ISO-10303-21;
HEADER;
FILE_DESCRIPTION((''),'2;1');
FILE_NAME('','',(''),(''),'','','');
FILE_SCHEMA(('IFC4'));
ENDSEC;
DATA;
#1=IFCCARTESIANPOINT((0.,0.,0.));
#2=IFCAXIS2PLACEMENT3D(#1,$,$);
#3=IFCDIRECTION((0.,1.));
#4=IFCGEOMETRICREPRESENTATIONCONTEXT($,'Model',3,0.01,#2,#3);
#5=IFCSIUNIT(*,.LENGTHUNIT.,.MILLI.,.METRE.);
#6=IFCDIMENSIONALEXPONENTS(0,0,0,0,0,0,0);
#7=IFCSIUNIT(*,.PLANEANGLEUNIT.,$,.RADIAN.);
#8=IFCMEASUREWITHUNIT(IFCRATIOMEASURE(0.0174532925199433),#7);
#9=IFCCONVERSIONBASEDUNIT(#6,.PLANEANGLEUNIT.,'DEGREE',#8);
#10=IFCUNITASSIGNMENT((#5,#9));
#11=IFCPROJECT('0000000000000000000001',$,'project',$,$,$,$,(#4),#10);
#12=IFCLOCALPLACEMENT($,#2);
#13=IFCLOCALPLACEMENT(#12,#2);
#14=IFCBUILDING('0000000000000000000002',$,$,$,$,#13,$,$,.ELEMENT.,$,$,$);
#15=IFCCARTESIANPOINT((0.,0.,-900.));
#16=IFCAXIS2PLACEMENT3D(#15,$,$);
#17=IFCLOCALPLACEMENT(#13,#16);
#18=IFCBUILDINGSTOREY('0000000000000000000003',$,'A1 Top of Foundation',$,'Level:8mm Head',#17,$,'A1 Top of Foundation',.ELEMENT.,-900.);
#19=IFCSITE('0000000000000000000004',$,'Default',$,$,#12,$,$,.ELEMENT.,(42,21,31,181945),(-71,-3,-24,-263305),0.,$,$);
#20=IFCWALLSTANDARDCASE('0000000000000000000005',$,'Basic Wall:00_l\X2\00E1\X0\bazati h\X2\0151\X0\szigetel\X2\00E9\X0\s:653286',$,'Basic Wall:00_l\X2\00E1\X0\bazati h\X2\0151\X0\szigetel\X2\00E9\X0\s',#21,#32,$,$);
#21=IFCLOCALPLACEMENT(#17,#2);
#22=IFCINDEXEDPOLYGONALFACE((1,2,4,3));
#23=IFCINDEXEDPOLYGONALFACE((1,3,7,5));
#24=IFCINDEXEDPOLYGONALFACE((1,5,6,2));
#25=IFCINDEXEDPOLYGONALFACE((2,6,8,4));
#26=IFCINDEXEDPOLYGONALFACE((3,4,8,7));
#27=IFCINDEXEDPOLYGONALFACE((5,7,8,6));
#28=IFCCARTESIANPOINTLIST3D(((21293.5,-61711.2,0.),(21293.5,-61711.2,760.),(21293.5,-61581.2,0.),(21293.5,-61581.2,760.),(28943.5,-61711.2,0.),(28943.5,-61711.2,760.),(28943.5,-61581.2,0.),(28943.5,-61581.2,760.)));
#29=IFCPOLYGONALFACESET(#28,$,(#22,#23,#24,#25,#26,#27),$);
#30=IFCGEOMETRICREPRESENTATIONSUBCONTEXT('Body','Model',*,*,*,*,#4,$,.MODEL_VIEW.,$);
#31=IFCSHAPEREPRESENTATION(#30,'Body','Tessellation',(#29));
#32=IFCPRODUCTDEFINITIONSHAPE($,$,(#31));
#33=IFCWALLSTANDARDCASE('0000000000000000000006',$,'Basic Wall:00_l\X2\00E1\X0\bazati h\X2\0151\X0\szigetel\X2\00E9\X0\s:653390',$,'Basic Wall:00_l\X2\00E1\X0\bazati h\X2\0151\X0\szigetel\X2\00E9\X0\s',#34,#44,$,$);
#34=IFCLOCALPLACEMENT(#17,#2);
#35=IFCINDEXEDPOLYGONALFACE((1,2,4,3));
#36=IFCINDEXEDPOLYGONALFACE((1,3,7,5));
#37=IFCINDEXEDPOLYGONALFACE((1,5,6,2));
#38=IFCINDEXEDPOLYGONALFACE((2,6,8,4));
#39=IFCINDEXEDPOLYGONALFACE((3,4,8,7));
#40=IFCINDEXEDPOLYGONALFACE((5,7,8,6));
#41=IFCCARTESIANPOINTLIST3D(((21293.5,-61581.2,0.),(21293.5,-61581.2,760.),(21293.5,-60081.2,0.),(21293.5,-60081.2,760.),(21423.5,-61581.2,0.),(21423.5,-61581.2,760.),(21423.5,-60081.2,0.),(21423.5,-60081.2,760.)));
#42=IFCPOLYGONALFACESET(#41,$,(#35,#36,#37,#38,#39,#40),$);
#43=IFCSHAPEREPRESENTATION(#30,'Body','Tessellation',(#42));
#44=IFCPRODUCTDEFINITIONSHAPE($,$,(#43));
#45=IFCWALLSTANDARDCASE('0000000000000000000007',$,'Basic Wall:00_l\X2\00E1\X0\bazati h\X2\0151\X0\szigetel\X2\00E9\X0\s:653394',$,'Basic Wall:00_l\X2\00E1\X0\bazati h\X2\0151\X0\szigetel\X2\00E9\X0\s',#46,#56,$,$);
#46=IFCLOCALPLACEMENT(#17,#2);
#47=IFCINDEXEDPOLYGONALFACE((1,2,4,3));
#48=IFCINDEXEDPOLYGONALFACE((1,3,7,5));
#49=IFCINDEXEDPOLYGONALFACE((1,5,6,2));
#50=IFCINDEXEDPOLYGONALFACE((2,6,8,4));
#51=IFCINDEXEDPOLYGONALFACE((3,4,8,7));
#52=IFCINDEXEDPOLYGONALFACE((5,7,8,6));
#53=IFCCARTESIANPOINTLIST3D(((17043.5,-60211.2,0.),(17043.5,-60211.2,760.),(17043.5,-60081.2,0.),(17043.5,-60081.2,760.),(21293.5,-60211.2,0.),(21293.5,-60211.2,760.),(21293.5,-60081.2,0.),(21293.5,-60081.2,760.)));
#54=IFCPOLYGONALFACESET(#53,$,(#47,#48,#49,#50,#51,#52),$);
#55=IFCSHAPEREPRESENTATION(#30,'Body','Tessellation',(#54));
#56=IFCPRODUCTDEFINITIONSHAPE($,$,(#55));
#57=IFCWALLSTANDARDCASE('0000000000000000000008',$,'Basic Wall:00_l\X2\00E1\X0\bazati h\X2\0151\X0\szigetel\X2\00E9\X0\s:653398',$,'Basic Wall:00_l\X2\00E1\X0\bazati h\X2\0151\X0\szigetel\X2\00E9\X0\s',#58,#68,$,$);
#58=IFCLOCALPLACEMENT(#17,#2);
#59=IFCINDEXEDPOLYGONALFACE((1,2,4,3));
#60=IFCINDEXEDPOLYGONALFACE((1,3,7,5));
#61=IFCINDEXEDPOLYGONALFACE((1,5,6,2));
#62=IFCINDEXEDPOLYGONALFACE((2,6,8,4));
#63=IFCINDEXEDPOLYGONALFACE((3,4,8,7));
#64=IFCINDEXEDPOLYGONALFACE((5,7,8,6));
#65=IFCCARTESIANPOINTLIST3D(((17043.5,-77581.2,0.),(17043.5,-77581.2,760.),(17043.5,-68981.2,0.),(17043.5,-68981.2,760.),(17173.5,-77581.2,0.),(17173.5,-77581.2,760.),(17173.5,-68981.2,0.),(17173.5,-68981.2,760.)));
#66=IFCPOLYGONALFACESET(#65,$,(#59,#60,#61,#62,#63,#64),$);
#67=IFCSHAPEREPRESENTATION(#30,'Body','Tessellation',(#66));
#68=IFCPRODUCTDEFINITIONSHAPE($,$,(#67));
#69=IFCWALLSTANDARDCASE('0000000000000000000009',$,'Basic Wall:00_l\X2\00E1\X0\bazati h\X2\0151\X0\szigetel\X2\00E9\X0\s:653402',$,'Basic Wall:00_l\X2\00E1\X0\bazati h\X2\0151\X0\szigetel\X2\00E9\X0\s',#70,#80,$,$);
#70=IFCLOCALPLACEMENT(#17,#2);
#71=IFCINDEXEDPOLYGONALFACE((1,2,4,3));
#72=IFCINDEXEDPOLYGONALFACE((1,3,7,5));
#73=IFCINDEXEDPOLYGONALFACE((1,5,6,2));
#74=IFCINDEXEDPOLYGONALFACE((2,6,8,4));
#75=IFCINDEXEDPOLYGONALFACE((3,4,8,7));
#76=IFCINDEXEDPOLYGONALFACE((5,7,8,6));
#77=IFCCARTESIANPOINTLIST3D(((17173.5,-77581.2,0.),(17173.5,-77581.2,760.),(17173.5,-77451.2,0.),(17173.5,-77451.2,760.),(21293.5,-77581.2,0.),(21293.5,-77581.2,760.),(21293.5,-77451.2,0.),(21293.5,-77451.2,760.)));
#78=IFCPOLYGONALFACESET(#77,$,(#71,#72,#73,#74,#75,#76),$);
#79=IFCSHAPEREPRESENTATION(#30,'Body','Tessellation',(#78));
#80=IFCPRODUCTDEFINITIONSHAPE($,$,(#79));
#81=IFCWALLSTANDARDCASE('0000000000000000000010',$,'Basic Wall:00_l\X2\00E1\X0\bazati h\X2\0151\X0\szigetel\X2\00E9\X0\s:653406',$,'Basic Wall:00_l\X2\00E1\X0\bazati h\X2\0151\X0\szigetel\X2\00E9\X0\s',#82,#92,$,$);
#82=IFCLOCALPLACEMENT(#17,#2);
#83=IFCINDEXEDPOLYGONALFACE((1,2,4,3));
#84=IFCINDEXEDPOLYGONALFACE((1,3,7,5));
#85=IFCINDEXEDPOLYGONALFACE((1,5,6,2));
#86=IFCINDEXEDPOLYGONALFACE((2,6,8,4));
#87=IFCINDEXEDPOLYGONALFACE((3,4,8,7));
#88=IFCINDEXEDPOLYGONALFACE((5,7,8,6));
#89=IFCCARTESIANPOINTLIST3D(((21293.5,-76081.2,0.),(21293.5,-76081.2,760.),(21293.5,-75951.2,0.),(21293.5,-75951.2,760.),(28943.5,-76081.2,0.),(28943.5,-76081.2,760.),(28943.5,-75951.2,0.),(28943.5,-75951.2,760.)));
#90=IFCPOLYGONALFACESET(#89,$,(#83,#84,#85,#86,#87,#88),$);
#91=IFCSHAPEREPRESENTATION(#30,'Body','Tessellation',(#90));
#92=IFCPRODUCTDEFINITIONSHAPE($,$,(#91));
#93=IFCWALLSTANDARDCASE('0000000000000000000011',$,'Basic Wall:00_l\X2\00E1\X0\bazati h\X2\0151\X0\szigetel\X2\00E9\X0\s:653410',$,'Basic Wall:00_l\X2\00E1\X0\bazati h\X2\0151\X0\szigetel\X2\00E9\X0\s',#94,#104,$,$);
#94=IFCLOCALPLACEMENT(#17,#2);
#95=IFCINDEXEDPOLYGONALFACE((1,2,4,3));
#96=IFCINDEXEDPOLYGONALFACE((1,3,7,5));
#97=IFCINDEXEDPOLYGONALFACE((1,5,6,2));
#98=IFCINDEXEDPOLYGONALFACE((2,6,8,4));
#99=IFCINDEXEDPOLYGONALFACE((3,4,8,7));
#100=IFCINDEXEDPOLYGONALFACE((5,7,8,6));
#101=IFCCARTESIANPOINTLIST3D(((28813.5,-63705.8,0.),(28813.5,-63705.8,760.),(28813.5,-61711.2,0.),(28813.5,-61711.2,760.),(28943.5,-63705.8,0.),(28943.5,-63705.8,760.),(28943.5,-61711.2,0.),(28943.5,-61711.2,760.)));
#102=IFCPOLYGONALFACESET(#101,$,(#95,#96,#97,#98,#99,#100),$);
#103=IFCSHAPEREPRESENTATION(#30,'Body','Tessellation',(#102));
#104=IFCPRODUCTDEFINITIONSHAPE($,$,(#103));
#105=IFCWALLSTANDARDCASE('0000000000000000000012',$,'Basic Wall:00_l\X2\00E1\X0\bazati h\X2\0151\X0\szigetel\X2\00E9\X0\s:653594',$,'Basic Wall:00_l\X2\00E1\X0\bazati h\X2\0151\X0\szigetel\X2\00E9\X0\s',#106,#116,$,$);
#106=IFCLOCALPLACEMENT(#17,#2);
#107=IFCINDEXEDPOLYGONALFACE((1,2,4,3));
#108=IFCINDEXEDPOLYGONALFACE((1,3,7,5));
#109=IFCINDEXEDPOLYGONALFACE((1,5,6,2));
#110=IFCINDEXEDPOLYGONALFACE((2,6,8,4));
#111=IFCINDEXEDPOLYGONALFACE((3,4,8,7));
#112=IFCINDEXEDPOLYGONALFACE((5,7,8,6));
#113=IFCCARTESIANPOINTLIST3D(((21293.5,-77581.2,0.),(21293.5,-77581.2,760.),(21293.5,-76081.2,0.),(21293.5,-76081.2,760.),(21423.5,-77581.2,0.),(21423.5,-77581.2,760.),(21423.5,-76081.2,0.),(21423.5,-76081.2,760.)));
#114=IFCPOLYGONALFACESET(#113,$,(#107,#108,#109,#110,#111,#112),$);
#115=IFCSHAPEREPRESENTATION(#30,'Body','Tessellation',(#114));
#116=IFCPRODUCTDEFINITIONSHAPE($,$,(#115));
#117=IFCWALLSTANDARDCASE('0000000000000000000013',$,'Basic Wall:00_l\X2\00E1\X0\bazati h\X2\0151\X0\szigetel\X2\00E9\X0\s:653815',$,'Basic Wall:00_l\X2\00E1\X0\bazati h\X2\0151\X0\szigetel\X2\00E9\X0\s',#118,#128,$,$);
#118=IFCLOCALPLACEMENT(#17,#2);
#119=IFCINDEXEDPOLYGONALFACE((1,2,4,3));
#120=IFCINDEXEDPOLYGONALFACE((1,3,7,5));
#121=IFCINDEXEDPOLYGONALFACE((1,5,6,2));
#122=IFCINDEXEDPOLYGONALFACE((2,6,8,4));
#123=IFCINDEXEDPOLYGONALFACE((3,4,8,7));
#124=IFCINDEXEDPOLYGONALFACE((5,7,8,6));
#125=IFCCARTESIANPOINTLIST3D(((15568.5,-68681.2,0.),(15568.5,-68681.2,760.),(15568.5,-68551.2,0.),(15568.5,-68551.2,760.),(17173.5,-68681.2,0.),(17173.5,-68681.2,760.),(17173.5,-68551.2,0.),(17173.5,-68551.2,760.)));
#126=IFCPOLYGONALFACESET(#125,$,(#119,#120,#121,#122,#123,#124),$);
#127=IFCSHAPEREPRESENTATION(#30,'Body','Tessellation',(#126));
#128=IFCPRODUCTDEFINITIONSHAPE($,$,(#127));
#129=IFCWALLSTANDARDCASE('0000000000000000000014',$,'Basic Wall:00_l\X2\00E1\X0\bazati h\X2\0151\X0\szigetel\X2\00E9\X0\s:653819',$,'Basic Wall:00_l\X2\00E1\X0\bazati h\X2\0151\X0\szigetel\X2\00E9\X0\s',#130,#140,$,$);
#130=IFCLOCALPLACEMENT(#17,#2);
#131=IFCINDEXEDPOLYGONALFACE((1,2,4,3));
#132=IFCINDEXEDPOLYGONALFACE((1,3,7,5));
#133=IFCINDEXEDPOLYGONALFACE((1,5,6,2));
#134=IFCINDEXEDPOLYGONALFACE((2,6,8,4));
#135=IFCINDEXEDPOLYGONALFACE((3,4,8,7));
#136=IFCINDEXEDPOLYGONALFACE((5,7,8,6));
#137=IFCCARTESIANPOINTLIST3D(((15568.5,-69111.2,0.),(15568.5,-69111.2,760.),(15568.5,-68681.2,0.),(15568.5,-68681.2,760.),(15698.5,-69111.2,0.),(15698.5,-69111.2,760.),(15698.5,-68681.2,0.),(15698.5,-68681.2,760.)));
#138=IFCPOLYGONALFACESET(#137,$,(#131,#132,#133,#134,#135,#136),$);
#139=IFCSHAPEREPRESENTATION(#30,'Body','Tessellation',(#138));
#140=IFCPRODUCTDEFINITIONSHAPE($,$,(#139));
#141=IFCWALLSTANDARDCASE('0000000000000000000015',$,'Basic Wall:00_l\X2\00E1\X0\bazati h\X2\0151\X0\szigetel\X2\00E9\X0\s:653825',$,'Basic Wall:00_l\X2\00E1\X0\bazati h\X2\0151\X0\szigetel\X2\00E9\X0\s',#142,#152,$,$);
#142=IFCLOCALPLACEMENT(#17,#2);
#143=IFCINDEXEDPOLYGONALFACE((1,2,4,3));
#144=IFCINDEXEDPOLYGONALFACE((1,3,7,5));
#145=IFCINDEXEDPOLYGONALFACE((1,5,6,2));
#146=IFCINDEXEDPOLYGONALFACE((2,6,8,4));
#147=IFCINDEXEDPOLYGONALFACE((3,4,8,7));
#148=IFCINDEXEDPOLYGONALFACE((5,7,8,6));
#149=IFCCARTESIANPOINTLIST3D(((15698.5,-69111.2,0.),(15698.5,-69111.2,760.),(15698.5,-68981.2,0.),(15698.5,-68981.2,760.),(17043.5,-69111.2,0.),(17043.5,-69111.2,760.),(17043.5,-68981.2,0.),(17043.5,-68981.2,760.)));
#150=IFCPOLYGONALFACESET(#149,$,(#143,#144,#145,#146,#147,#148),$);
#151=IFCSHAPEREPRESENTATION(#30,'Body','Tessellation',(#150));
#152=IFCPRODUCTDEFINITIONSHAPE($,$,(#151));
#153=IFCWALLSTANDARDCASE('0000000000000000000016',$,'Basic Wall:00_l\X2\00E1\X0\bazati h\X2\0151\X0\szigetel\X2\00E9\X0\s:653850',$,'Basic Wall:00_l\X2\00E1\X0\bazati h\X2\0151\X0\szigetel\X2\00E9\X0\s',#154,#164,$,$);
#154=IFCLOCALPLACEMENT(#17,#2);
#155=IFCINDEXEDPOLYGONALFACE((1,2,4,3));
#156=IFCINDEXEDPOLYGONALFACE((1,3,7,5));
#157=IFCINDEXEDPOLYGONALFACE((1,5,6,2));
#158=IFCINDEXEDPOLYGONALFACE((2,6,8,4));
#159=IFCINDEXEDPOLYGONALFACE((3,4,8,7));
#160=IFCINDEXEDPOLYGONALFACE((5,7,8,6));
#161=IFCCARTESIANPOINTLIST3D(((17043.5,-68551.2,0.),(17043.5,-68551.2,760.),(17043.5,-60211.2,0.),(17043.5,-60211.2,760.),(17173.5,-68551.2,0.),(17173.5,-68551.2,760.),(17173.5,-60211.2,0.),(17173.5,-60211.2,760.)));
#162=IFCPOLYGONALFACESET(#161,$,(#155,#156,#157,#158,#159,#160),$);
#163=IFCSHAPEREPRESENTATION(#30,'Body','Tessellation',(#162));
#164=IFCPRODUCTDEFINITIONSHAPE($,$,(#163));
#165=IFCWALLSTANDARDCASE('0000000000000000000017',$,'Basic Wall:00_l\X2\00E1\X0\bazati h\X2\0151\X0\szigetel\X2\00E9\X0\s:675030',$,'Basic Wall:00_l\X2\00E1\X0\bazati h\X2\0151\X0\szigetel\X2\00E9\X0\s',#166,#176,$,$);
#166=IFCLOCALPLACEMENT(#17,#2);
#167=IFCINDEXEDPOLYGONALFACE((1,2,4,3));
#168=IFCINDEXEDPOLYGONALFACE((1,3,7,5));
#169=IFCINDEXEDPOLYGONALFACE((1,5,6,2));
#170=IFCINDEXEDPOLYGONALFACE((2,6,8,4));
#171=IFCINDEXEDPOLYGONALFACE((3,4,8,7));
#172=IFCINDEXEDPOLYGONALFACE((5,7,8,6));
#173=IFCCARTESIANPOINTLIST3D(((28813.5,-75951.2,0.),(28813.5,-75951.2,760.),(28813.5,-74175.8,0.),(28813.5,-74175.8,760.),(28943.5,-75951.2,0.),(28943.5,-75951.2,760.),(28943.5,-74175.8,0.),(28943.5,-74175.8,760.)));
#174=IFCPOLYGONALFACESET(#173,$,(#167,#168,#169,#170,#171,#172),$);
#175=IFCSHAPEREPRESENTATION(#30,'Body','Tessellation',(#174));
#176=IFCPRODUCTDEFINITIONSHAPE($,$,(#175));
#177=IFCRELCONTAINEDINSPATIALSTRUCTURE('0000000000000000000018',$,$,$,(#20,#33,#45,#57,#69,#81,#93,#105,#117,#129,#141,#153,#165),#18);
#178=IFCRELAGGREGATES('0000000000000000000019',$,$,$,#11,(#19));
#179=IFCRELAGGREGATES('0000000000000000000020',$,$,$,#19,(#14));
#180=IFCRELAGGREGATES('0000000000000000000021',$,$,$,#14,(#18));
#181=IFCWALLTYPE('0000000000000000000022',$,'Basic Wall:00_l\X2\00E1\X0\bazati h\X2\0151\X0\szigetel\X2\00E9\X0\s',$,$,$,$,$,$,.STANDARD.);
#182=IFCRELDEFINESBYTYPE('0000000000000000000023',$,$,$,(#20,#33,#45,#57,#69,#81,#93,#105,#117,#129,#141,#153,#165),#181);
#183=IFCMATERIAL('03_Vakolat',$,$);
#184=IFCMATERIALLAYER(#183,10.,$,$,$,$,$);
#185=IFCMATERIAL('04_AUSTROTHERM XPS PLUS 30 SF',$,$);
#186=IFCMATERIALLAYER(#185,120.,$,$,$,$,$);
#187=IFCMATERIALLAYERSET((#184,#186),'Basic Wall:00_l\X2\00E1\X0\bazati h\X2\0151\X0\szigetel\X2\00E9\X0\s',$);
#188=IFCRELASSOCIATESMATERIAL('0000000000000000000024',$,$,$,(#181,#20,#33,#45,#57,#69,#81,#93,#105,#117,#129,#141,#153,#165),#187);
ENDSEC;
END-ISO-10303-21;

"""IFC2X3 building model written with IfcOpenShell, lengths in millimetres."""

from ifc_helpers import new_model, entity, si_unit, converted_unit, direction, frame, frame_2d, origin, place, context, subcontext, project, spatial, rectangle, extrude, material, layer, layer_set, layer_usage, type_object, element, save


model = new_model("IFC2X3")

# Units and contexts
model_context = context("Model", 3, precision=0.01, world=origin(), true_north=direction((0.0, 1.0)))
body_context = subcontext(model_context, "Body", "Model", "MODEL_VIEW")
ifc_project = project(units=[si_unit("LENGTHUNIT", "METRE", prefix="MILLI"), converted_unit("PLANEANGLEUNIT", "DEGREE", entity("IfcRatioMeasure", 0.0174532925199433), si_unit("PLANEANGLEUNIT", "RADIAN"), dimensions=[0, 0, 0, 0, 0, 0, 0])], contexts=[model_context])

# Site, building, storey
site_placement = place(None, origin())
site = spatial("IfcSite", under=ifc_project, at=site_placement, Name="Default", CompositionType="ELEMENT", RefLatitude=(42, 21, 31, 181945), RefLongitude=(-71, -3, -24, -263305), RefElevation=0.0)
building_placement = place(site_placement, origin())
building = spatial("IfcBuilding", under=site, at=building_placement, CompositionType="ELEMENT")
storey_placement = place(building_placement, frame((0.0, 0.0, -900.0)))
storey = spatial("IfcBuildingStorey", under=building, at=storey_placement, Name="A1 Top of Foundation", ObjectType="Level:8mm Head", LongName="A1 Top of Foundation", CompositionType="ELEMENT", Elevation=-900.0)

# Walls
ifc_material_1 = material(Name="03_Vakolat")
ifc_layer_1 = layer(ifc_material_1, 10.0)
ifc_material_2 = material(Name="04_AUSTROTHERM XPS PLUS 30 SF")
ifc_layer_2 = layer(ifc_material_2, 120.0)
ifc_layer_set = layer_set([ifc_layer_1, ifc_layer_2], Name="Basic Wall:00_lábazati hőszigetelés")
ifc_layer_usage_1 = layer_usage(ifc_layer_set, "AXIS2", "NEGATIVE", 65.0)
wall_type = type_object("IfcWallType", Name="Basic Wall:00_lábazati hőszigetelés", PredefinedType="STANDARD", material=ifc_layer_set)
wall_1_placement = place(storey_placement, frame((21293.5, -61646.2, 0.0)))
element("IfcWallStandardCase", 1, at=wall_1_placement, inside=storey, type_object=wall_type, material=ifc_layer_usage_1, Name="Basic Wall:00_lábazati hőszigetelés:653286", ObjectType="Basic Wall:00_lábazati hőszigetelés", context=body_context, shape_type="SweptSolid", body=[
    extrude(rectangle(XDim=7650.0, YDim=130.0, at=frame_2d((3825.0, 0.0), x_axis=(-1.0, 0.0))), origin(), (0.0, 0.0, 1.0), 760.0),
])
ifc_layer_usage_2 = layer_usage(ifc_layer_set, "AXIS2", "NEGATIVE", 65.0)
wall_2_placement = place(storey_placement, frame((21358.5, -60081.2, 0.0), z_axis=(0.0, 0.0, 1.0), x_axis=(0.0, -1.0, 0.0)))
element("IfcWallStandardCase", 2, at=wall_2_placement, inside=storey, type_object=wall_type, material=ifc_layer_usage_2, Name="Basic Wall:00_lábazati hőszigetelés:653390", ObjectType="Basic Wall:00_lábazati hőszigetelés", context=body_context, shape_type="SweptSolid", body=[
    extrude(rectangle(XDim=1500.0, YDim=130.0, at=frame_2d((750.0, 0.0), x_axis=(-1.0, 0.0))), origin(), (0.0, 0.0, 1.0), 760.0),
])
ifc_layer_usage_3 = layer_usage(ifc_layer_set, "AXIS2", "NEGATIVE", 65.0)
wall_3_placement = place(storey_placement, frame((17043.5, -60146.2, 0.0)))
element("IfcWallStandardCase", 3, at=wall_3_placement, inside=storey, type_object=wall_type, material=ifc_layer_usage_3, Name="Basic Wall:00_lábazati hőszigetelés:653394", ObjectType="Basic Wall:00_lábazati hőszigetelés", context=body_context, shape_type="SweptSolid", body=[
    extrude(rectangle(XDim=4250.0, YDim=130.0, at=frame_2d((2125.0, 0.0), x_axis=(-1.0, 0.0))), origin(), (0.0, 0.0, 1.0), 760.0),
])
ifc_layer_usage_4 = layer_usage(ifc_layer_set, "AXIS2", "NEGATIVE", 65.0)
wall_4_placement = place(storey_placement, frame((17108.5, -77581.2, 0.0), z_axis=(0.0, 0.0, 1.0), x_axis=(0.0, 1.0, 0.0)))
element("IfcWallStandardCase", 4, at=wall_4_placement, inside=storey, type_object=wall_type, material=ifc_layer_usage_4, Name="Basic Wall:00_lábazati hőszigetelés:653398", ObjectType="Basic Wall:00_lábazati hőszigetelés", context=body_context, shape_type="SweptSolid", body=[
    extrude(rectangle(XDim=8600.0, YDim=130.0, at=frame_2d((4300.0, 0.0), x_axis=(-1.0, 0.0))), origin(), (0.0, 0.0, 1.0), 760.0),
])
ifc_layer_usage_5 = layer_usage(ifc_layer_set, "AXIS2", "NEGATIVE", 65.0)
wall_5_placement = place(storey_placement, frame((21293.5, -77516.2, 0.0), z_axis=(0.0, 0.0, 1.0), x_axis=(-1.0, 0.0, 0.0)))
element("IfcWallStandardCase", 5, at=wall_5_placement, inside=storey, type_object=wall_type, material=ifc_layer_usage_5, Name="Basic Wall:00_lábazati hőszigetelés:653402", ObjectType="Basic Wall:00_lábazati hőszigetelés", context=body_context, shape_type="SweptSolid", body=[
    extrude(rectangle(XDim=4120.0, YDim=130.0, at=frame_2d((2060.0, 0.0), x_axis=(-1.0, 0.0))), origin(), (0.0, 0.0, 1.0), 760.0),
])
ifc_layer_usage_6 = layer_usage(ifc_layer_set, "AXIS2", "NEGATIVE", 65.0)
wall_6_placement = place(storey_placement, frame((28943.5, -76016.2, 0.0), z_axis=(0.0, 0.0, 1.0), x_axis=(-1.0, 0.0, 0.0)))
element("IfcWallStandardCase", 6, at=wall_6_placement, inside=storey, type_object=wall_type, material=ifc_layer_usage_6, Name="Basic Wall:00_lábazati hőszigetelés:653406", ObjectType="Basic Wall:00_lábazati hőszigetelés", context=body_context, shape_type="SweptSolid", body=[
    extrude(rectangle(XDim=7650.0, YDim=130.0, at=frame_2d((3825.0, 0.0), x_axis=(-1.0, 0.0))), origin(), (0.0, 0.0, 1.0), 760.0),
])
ifc_layer_usage_7 = layer_usage(ifc_layer_set, "AXIS2", "NEGATIVE", 65.0)
wall_7_placement = place(storey_placement, frame((28878.5, -61711.2, 0.0), z_axis=(0.0, 0.0, 1.0), x_axis=(0.0, -1.0, 0.0)))
element("IfcWallStandardCase", 7, at=wall_7_placement, inside=storey, type_object=wall_type, material=ifc_layer_usage_7, Name="Basic Wall:00_lábazati hőszigetelés:653410", ObjectType="Basic Wall:00_lábazati hőszigetelés", context=body_context, shape_type="SweptSolid", body=[
    extrude(rectangle(XDim=1994.6, YDim=130.0, at=frame_2d((997.3, 0.0), x_axis=(-1.0, 0.0))), origin(), (0.0, 0.0, 1.0), 760.0),
])
ifc_layer_usage_8 = layer_usage(ifc_layer_set, "AXIS2", "NEGATIVE", 65.0)
wall_8_placement = place(storey_placement, frame((21358.5, -76081.2, 0.0), z_axis=(0.0, 0.0, 1.0), x_axis=(0.0, -1.0, 0.0)))
element("IfcWallStandardCase", 8, at=wall_8_placement, inside=storey, type_object=wall_type, material=ifc_layer_usage_8, Name="Basic Wall:00_lábazati hőszigetelés:653594", ObjectType="Basic Wall:00_lábazati hőszigetelés", context=body_context, shape_type="SweptSolid", body=[
    extrude(rectangle(XDim=1500.0, YDim=130.0, at=frame_2d((750.0, 0.0), x_axis=(-1.0, 0.0))), origin(), (0.0, 0.0, 1.0), 760.0),
])
ifc_layer_usage_9 = layer_usage(ifc_layer_set, "AXIS2", "NEGATIVE", 65.0)
wall_9_placement = place(storey_placement, frame((15568.5, -68616.2, 0.0)))
element("IfcWallStandardCase", 9, at=wall_9_placement, inside=storey, type_object=wall_type, material=ifc_layer_usage_9, Name="Basic Wall:00_lábazati hőszigetelés:653815", ObjectType="Basic Wall:00_lábazati hőszigetelés", context=body_context, shape_type="SweptSolid", body=[
    extrude(rectangle(XDim=1605.0, YDim=130.0, at=frame_2d((802.5, 0.0), x_axis=(-1.0, 0.0))), origin(), (0.0, 0.0, 1.0), 760.0),
])
ifc_layer_usage_10 = layer_usage(ifc_layer_set, "AXIS2", "NEGATIVE", 65.0)
wall_10_placement = place(storey_placement, frame((15633.5, -69111.2, 0.0), z_axis=(0.0, 0.0, 1.0), x_axis=(0.0, 1.0, 0.0)))
element("IfcWallStandardCase", 10, at=wall_10_placement, inside=storey, type_object=wall_type, material=ifc_layer_usage_10, Name="Basic Wall:00_lábazati hőszigetelés:653819", ObjectType="Basic Wall:00_lábazati hőszigetelés", context=body_context, shape_type="SweptSolid", body=[
    extrude(rectangle(XDim=430.0, YDim=130.0, at=frame_2d((215.0, 0.0), x_axis=(-1.0, 0.0))), origin(), (0.0, 0.0, 1.0), 760.0),
])
ifc_layer_usage_11 = layer_usage(ifc_layer_set, "AXIS2", "NEGATIVE", 65.0)
wall_11_placement = place(storey_placement, frame((17043.5, -69046.2, 0.0), z_axis=(0.0, 0.0, 1.0), x_axis=(-1.0, 0.0, 0.0)))
element("IfcWallStandardCase", 11, at=wall_11_placement, inside=storey, type_object=wall_type, material=ifc_layer_usage_11, Name="Basic Wall:00_lábazati hőszigetelés:653825", ObjectType="Basic Wall:00_lábazati hőszigetelés", context=body_context, shape_type="SweptSolid", body=[
    extrude(rectangle(XDim=1345.0, YDim=130.0, at=frame_2d((672.5, 0.0), x_axis=(-1.0, 0.0))), origin(), (0.0, 0.0, 1.0), 760.0),
])
ifc_layer_usage_12 = layer_usage(ifc_layer_set, "AXIS2", "NEGATIVE", 65.0)
wall_12_placement = place(storey_placement, frame((17108.5, -68551.2, 0.0), z_axis=(0.0, 0.0, 1.0), x_axis=(0.0, 1.0, 0.0)))
element("IfcWallStandardCase", 12, at=wall_12_placement, inside=storey, type_object=wall_type, material=ifc_layer_usage_12, Name="Basic Wall:00_lábazati hőszigetelés:653850", ObjectType="Basic Wall:00_lábazati hőszigetelés", context=body_context, shape_type="SweptSolid", body=[
    extrude(rectangle(XDim=8340.0, YDim=130.0, at=frame_2d((4170.0, 0.0), x_axis=(-1.0, 0.0))), origin(), (0.0, 0.0, 1.0), 760.0),
])
ifc_layer_usage_13 = layer_usage(ifc_layer_set, "AXIS2", "NEGATIVE", 65.0)
wall_13_placement = place(storey_placement, frame((28878.5, -74175.8, 0.0), z_axis=(0.0, 0.0, 1.0), x_axis=(0.0, -1.0, 0.0)))
element("IfcWallStandardCase", 13, at=wall_13_placement, inside=storey, type_object=wall_type, material=ifc_layer_usage_13, Name="Basic Wall:00_lábazati hőszigetelés:675030", ObjectType="Basic Wall:00_lábazati hőszigetelés", context=body_context, shape_type="SweptSolid", body=[
    extrude(rectangle(XDim=1775.4, YDim=130.0, at=frame_2d((887.7, 0.0), x_axis=(-1.0, 0.0))), origin(), (0.0, 0.0, 1.0), 760.0),
])

save(model, "model.ifc")
